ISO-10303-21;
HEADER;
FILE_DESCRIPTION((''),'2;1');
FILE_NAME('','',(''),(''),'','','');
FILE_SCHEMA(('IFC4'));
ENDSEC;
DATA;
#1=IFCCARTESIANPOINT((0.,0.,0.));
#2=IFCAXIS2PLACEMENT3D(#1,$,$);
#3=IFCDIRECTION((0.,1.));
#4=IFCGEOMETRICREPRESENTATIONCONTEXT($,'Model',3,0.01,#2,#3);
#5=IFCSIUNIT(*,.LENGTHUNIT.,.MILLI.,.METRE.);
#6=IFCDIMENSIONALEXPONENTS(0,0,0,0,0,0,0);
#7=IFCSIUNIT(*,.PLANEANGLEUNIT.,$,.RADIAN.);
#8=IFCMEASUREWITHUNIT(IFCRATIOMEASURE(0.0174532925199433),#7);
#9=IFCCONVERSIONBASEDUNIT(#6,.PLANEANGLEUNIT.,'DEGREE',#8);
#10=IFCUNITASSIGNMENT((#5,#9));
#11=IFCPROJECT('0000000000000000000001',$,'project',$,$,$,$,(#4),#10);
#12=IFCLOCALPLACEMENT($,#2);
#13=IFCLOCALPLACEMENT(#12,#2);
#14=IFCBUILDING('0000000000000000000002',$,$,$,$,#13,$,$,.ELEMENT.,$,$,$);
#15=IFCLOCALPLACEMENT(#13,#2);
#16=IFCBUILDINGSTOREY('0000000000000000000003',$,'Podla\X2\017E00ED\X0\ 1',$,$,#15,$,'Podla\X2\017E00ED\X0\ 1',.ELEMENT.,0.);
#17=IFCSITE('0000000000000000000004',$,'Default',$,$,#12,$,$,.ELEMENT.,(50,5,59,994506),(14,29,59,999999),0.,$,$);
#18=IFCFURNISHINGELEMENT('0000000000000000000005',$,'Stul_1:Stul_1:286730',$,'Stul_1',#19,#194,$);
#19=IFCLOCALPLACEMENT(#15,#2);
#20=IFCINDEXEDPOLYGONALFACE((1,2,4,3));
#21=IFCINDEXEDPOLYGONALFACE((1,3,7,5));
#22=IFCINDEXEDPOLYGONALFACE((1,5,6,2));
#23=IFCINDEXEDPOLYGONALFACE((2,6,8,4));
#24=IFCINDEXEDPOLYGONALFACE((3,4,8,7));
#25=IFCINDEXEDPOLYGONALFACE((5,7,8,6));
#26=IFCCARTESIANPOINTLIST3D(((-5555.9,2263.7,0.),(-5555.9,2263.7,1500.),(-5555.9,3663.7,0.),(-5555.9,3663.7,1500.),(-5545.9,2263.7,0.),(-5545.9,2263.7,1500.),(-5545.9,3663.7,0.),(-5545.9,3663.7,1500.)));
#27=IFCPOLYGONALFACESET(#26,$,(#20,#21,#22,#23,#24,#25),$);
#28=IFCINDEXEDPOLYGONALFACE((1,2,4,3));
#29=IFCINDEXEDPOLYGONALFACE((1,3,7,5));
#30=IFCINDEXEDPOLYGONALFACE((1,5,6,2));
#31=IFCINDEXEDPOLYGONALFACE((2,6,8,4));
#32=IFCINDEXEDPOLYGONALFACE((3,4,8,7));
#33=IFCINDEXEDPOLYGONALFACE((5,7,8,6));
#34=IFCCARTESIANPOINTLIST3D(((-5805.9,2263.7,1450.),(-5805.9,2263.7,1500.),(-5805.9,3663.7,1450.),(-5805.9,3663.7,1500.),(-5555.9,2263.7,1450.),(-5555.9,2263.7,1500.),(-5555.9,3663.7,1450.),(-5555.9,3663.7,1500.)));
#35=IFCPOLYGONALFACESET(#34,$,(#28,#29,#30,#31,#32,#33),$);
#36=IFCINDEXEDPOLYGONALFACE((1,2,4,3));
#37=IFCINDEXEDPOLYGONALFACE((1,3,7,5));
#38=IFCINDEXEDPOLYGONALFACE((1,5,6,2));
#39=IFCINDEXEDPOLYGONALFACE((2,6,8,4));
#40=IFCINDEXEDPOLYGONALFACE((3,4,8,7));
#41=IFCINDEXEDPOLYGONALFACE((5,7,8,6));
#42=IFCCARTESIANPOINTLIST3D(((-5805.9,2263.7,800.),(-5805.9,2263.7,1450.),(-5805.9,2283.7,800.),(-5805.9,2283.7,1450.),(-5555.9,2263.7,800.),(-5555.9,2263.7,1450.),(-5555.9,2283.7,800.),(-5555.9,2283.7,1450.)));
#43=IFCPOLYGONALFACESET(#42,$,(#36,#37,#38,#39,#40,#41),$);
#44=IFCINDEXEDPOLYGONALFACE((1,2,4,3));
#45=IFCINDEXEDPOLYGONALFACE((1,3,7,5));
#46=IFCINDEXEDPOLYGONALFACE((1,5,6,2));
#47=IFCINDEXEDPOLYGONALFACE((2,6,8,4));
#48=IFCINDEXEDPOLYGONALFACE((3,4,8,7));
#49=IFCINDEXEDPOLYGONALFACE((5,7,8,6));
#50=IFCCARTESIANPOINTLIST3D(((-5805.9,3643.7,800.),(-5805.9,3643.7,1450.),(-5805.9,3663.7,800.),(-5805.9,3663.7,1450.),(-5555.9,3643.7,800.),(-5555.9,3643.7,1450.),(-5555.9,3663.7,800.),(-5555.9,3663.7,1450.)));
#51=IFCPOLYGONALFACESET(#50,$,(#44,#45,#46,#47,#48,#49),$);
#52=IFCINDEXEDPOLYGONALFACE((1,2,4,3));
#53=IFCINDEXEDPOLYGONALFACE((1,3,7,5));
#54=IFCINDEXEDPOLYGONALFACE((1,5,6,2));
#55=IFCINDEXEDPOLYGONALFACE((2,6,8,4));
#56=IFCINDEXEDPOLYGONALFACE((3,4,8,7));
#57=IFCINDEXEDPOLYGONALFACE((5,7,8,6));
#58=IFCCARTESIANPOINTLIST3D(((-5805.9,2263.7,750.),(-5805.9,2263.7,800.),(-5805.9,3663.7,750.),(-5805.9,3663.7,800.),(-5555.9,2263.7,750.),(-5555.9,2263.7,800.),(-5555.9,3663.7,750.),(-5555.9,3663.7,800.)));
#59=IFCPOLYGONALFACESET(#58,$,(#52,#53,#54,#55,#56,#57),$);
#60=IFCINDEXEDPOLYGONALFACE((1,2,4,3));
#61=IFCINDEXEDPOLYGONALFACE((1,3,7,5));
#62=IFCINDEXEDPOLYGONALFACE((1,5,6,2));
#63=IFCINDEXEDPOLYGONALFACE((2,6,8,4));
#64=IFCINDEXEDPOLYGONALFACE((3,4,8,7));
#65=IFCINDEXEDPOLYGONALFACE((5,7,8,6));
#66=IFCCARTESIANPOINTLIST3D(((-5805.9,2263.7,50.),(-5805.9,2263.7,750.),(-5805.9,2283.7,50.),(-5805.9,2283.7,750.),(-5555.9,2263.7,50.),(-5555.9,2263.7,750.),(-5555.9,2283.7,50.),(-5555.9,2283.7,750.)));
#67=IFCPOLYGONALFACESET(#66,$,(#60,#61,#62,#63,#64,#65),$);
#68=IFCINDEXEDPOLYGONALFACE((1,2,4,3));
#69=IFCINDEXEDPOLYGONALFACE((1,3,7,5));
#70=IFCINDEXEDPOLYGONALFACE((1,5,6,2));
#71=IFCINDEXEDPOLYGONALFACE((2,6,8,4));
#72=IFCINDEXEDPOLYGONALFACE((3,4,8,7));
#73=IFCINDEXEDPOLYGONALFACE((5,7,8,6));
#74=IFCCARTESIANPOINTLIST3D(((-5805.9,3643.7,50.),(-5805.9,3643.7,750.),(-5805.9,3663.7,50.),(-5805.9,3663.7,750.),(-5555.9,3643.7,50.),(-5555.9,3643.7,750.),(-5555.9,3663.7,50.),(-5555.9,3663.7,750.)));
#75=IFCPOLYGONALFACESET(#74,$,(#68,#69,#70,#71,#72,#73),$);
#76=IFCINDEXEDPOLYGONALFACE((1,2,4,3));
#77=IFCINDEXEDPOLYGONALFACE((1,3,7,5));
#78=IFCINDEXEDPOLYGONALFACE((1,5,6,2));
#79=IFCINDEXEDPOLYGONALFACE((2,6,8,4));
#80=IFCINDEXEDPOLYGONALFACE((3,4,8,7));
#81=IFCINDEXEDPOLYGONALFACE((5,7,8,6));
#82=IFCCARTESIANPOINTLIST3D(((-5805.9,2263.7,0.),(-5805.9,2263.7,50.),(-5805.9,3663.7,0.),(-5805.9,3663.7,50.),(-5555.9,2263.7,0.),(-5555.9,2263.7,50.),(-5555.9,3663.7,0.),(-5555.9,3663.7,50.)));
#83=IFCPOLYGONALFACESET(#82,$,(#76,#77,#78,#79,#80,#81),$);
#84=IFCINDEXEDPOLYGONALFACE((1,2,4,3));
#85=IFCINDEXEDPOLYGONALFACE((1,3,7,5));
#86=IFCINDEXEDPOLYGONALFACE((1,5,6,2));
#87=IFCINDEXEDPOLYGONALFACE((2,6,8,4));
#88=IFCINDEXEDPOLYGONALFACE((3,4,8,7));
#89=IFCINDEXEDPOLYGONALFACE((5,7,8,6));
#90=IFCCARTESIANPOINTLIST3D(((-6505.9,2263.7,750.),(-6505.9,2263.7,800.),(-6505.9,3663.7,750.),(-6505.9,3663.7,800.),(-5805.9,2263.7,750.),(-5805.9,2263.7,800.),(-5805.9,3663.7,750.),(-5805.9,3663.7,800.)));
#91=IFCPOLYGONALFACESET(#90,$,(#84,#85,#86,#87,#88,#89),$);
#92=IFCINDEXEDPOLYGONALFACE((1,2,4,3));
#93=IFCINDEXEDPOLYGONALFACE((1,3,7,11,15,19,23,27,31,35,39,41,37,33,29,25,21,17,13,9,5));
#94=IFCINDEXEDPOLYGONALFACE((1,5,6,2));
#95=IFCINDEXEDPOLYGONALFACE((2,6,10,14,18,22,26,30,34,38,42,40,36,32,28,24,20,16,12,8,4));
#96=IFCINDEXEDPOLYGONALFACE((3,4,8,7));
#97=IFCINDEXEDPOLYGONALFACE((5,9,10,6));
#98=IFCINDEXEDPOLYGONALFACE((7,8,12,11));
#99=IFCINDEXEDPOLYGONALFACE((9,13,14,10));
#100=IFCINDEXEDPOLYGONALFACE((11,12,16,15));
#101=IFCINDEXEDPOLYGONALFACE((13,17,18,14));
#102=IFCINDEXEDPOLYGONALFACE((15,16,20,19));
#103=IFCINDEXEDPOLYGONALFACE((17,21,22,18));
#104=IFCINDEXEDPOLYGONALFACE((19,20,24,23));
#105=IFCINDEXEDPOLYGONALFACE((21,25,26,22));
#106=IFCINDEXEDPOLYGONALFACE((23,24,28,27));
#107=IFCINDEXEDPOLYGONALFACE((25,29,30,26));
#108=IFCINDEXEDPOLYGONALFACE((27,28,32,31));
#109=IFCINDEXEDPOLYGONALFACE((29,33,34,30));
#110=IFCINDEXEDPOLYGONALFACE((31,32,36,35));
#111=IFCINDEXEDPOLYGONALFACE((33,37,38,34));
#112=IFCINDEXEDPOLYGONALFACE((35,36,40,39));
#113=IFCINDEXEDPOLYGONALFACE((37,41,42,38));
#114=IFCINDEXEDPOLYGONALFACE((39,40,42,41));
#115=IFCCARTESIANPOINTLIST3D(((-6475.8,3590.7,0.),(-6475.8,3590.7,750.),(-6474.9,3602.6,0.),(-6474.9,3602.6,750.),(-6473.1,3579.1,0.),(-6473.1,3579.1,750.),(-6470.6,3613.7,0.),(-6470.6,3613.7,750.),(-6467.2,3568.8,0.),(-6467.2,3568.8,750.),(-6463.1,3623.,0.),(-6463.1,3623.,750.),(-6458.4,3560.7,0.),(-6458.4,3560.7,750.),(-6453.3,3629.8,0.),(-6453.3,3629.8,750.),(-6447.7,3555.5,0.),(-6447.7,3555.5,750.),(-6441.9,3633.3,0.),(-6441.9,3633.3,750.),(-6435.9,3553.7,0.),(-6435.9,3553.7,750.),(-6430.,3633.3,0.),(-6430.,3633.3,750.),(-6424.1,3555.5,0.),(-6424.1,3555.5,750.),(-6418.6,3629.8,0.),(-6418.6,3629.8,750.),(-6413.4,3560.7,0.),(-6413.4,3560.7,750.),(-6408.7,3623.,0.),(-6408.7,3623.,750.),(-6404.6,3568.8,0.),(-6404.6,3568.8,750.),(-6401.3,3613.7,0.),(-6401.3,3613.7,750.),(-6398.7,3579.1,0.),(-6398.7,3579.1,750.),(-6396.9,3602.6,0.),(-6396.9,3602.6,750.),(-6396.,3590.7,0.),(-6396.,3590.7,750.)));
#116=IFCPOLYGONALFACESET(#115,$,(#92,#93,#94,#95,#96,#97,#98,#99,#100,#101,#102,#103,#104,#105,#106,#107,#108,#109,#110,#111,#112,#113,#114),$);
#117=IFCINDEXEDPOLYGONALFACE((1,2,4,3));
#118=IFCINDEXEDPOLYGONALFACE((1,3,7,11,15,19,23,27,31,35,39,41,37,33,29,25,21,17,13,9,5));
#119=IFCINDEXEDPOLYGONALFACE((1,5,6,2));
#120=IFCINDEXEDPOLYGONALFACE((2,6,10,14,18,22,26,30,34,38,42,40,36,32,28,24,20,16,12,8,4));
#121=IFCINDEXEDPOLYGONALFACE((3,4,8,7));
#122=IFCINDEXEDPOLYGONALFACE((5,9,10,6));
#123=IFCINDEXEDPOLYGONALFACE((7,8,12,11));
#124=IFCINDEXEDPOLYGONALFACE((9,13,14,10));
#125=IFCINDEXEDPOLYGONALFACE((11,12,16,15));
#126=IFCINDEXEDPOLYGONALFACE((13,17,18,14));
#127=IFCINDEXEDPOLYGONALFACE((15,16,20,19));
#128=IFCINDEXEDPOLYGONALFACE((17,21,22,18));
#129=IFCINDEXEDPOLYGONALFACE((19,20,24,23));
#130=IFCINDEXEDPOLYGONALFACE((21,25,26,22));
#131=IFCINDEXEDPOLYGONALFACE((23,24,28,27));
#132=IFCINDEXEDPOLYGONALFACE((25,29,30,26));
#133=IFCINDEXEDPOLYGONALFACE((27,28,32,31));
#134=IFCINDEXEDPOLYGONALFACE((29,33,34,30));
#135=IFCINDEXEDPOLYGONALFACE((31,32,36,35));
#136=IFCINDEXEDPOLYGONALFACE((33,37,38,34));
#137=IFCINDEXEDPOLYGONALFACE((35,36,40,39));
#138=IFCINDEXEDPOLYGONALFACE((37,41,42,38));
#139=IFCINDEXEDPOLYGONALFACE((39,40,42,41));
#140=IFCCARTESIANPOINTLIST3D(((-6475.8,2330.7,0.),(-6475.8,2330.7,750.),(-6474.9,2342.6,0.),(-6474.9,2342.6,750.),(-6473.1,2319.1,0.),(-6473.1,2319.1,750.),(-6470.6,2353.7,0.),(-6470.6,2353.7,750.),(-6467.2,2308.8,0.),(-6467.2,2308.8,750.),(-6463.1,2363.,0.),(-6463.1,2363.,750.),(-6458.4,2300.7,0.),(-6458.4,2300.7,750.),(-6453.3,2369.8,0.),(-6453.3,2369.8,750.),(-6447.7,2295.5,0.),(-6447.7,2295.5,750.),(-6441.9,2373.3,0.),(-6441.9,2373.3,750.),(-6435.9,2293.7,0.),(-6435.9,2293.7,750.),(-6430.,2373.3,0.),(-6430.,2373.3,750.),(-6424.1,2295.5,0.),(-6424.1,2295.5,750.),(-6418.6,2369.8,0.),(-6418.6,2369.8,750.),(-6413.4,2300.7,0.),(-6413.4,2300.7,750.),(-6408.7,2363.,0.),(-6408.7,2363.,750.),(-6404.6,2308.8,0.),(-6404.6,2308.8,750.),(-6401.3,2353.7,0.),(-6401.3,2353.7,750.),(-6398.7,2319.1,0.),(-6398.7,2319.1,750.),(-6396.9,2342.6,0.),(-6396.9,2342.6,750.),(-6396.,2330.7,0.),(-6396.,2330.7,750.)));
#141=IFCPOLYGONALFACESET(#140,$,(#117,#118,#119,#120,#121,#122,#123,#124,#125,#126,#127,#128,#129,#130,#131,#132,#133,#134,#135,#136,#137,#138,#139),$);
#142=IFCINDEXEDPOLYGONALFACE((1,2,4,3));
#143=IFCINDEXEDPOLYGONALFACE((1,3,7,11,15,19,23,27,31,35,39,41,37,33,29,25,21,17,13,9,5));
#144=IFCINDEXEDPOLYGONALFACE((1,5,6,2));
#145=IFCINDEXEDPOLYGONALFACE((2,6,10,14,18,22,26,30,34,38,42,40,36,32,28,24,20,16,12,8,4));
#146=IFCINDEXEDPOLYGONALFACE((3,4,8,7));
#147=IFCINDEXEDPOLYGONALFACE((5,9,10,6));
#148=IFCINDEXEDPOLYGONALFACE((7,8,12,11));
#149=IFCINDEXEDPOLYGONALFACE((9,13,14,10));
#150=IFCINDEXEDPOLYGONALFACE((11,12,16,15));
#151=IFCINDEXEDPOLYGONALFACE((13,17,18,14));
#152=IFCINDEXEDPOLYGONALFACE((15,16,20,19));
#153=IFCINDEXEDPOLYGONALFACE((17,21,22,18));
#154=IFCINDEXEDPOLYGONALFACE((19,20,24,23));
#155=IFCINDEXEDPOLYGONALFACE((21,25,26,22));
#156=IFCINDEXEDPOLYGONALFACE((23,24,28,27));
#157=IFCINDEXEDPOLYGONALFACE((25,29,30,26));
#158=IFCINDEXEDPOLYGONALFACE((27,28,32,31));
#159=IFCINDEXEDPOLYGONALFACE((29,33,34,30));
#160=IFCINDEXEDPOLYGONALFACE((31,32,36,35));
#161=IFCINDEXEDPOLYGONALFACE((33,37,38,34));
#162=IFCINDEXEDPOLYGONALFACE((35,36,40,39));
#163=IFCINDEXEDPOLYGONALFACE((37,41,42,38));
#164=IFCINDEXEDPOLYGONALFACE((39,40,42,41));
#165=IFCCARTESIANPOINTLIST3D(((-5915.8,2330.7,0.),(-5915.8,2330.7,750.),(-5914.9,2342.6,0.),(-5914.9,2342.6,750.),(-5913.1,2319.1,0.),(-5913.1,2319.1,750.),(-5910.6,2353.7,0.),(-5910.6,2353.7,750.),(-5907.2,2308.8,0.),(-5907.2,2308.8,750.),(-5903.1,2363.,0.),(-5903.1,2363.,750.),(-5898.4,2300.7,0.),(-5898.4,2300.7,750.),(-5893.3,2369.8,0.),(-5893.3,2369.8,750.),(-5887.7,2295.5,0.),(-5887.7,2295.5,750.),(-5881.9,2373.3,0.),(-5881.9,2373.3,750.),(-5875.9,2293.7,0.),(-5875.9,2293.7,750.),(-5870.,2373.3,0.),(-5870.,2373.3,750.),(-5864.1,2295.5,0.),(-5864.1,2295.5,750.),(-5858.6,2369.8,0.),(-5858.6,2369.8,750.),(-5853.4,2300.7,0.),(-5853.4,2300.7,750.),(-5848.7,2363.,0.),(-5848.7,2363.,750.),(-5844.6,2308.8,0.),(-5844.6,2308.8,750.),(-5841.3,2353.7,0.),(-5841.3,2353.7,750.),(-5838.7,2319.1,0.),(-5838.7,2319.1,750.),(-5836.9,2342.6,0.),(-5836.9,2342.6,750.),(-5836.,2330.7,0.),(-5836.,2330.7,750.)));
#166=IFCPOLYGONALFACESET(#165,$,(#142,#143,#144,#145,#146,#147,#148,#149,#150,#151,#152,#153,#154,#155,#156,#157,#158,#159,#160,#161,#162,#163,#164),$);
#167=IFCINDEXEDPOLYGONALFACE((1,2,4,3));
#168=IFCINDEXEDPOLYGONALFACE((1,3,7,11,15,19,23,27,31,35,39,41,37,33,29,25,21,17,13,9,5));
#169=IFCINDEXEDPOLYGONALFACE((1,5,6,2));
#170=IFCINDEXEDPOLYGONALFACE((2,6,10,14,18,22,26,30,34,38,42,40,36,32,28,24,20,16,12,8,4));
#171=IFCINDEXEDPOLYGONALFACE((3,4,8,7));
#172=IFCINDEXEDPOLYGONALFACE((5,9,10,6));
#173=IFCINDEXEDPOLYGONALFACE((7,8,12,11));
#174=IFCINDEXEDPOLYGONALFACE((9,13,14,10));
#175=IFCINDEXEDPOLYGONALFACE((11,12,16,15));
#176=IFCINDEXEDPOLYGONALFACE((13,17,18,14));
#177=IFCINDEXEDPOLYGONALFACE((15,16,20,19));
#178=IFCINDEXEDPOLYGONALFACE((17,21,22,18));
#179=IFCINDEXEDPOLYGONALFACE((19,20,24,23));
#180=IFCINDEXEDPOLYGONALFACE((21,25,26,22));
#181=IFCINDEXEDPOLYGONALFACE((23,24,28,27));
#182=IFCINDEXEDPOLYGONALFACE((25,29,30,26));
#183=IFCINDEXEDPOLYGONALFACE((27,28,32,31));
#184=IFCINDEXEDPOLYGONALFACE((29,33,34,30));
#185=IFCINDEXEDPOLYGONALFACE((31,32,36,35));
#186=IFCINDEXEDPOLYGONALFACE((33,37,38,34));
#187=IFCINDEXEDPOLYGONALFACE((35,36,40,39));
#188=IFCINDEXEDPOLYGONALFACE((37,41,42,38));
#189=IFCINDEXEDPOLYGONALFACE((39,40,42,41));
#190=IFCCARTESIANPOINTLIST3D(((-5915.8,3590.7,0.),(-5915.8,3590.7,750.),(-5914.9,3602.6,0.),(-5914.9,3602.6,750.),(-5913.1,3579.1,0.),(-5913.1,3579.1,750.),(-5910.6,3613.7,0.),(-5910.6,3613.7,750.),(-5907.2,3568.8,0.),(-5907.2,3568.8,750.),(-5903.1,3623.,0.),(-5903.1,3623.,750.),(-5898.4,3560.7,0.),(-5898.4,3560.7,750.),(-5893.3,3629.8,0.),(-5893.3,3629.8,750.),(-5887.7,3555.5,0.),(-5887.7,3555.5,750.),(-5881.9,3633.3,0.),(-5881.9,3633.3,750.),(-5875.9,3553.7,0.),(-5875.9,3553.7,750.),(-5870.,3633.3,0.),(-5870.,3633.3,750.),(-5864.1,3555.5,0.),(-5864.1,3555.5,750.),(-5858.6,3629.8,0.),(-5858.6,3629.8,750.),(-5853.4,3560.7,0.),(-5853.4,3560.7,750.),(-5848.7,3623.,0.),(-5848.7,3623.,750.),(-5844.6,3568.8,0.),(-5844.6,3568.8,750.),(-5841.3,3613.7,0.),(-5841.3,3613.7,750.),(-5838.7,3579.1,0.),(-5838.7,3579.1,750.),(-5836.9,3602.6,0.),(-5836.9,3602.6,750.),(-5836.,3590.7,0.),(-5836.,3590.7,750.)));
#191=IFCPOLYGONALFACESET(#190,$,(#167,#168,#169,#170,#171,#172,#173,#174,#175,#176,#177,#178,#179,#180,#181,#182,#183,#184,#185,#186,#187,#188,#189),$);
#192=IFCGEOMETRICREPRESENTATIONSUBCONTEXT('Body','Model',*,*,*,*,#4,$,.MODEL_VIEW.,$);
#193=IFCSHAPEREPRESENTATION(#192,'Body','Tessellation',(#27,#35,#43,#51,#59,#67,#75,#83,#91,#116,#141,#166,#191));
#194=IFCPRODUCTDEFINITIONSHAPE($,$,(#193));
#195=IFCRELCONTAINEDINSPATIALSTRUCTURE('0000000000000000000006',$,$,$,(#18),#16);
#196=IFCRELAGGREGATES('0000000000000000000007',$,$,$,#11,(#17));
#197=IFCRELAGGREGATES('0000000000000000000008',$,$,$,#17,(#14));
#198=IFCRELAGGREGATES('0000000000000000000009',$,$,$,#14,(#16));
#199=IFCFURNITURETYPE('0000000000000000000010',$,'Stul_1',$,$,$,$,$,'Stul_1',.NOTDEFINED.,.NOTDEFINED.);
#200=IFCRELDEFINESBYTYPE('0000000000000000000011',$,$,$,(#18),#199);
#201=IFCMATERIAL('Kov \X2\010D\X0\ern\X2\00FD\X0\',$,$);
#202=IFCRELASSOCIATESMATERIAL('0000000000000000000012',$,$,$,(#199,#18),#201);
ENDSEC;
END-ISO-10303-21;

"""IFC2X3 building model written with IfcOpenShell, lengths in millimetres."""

from ifc_helpers import new_model, entity, si_unit, converted_unit, direction, frame, frame_2d, origin, origin_2d_with_axis, place, context, subcontext, project, spatial, rectangle, circle, extrude, source, transform, mapped, material, type_object, type_shapes, element, save


model = new_model("IFC2X3")

# Units and contexts
model_context = context("Model", 3, precision=0.01, world=origin(), true_north=direction((0.0, 1.0)))
body_context = subcontext(model_context, "Body", "Model", "MODEL_VIEW")
ifc_project = project(units=[si_unit("LENGTHUNIT", "METRE", prefix="MILLI"), converted_unit("PLANEANGLEUNIT", "DEGREE", entity("IfcRatioMeasure", 0.0174532925199433), si_unit("PLANEANGLEUNIT", "RADIAN"), dimensions=[0, 0, 0, 0, 0, 0, 0])], contexts=[model_context])

# Site, building, storey
site_placement = place(None, origin())
site = spatial("IfcSite", under=ifc_project, at=site_placement, Name="Default", CompositionType="ELEMENT", RefLatitude=(50, 5, 59, 994506), RefLongitude=(14, 29, 59, 999999), RefElevation=0.0)
building_placement = place(site_placement, origin())
building = spatial("IfcBuilding", under=site, at=building_placement, CompositionType="ELEMENT")
storey_placement = place(building_placement, origin())
storey = spatial("IfcBuildingStorey", under=building, at=storey_placement, Name="Podlaží 1", LongName="Podlaží 1", CompositionType="ELEMENT", Elevation=0.0)

# Furnishing element
ifc_material_1 = material(Name="Kov černý")
furniture_type = type_object("IfcFurnitureType", Name="Stul_1", ElementType="Stul_1", material=ifc_material_1)
shared_shape_1 = source(origin(), body_context, "Body", "SweptSolid", [
    extrude(rectangle(XDim=1400.0, YDim=10.0, at=origin_2d_with_axis()), frame((0.0, 605.0, 0.0), z_axis=(0.0, 0.0, 1.0), x_axis=(-1.0, 0.0, 0.0)), (0.0, 0.0, 1.0), 1500.0),
    extrude(rectangle(XDim=1400.0, YDim=250.0, at=frame_2d((0.0, 0.0), x_axis=(1.0, 0.0))), frame((0.0, 475.0, 1450.0), z_axis=(0.0, 0.0, 1.0), x_axis=(-1.0, 0.0, 0.0)), (0.0, 0.0, 1.0), 50.0),
    extrude(rectangle(XDim=20.0, YDim=250.0, at=origin_2d_with_axis()), frame((690.0, 475.0, 800.0), z_axis=(0.0, 0.0, 1.0), x_axis=(-1.0, 0.0, 0.0)), (0.0, 0.0, 1.0), 650.0),
    extrude(rectangle(XDim=20.0, YDim=250.0, at=frame_2d((0.0, 0.0), x_axis=(1.0, 0.0))), frame((-690.0, 475.0, 800.0), z_axis=(0.0, 0.0, 1.0), x_axis=(-1.0, 0.0, 0.0)), (0.0, 0.0, 1.0), 650.0),
    extrude(rectangle(XDim=1400.0, YDim=250.0, at=origin_2d_with_axis()), frame((0.0, 475.0, 750.0), z_axis=(0.0, 0.0, 1.0), x_axis=(-1.0, 0.0, 0.0)), (0.0, 0.0, 1.0), 50.0),
    extrude(rectangle(XDim=20.0, YDim=250.0, at=origin_2d_with_axis()), frame((690.0, 475.0, 50.0), z_axis=(0.0, 0.0, 1.0), x_axis=(-1.0, 0.0, 0.0)), (0.0, 0.0, 1.0), 700.0),
    extrude(rectangle(XDim=20.0, YDim=250.0, at=frame_2d((0.0, 0.0), x_axis=(1.0, 0.0))), frame((-690.0, 475.0, 50.0), z_axis=(0.0, 0.0, 1.0), x_axis=(-1.0, 0.0, 0.0)), (0.0, 0.0, 1.0), 700.0),
    extrude(rectangle(XDim=1400.0, YDim=250.0, at=origin_2d_with_axis()), frame((0.0, 475.0, 0.0), z_axis=(0.0, 0.0, 1.0), x_axis=(-1.0, 0.0, 0.0)), (0.0, 0.0, 1.0), 50.0),
    extrude(rectangle(XDim=1400.0, YDim=700.0, at=origin_2d_with_axis()), frame((0.0, 0.0, 750.0), z_axis=(0.0, 0.0, 1.0), x_axis=(-1.0, 0.0, 0.0)), (0.0, 0.0, 1.0), 50.0),
    extrude(circle(Radius=40.0, at=frame_2d((0.0, 0.0), x_axis=(1.0, 0.0))), frame((-630.0, -280.0, 0.0)), (0.0, 0.0, 1.0), 750.0),
    extrude(circle(Radius=40.0, at=frame_2d((0.0, 0.0), x_axis=(1.0, 0.0))), frame((630.0, -280.0, 0.0)), (0.0, 0.0, 1.0), 750.0),
    extrude(circle(Radius=40.0, at=frame_2d((0.0, 0.0), x_axis=(1.0, 0.0))), frame((630.0, 280.0, 0.0)), (0.0, 0.0, 1.0), 750.0),
    extrude(circle(Radius=40.0, at=frame_2d((0.0, 0.0), x_axis=(1.0, 0.0))), frame((-630.0, 280.0, 0.0)), (0.0, 0.0, 1.0), 750.0),
])
type_shapes(furniture_type, [shared_shape_1])
for number, where, z_axis, x_axis, name in (
    (1, (-6155.9, 2963.7, 0.0), (0.0, 0.0, 1.0), (0.0, -1.0, 0.0), "Stul_1:Stul_1:286730"),
):
    element("IfcFurnishingElement", number, at=place(storey_placement, frame(where, z_axis=z_axis, x_axis=x_axis)), inside=storey, type_object=furniture_type, material=ifc_material_1, Name=name, ObjectType="Stul_1", context=body_context, shape_type="MappedRepresentation", body=[
        mapped(shared_shape_1, transform((0.0, 0.0, 0.0), scale=1.0)),
    ])

save(model, "model.ifc")
